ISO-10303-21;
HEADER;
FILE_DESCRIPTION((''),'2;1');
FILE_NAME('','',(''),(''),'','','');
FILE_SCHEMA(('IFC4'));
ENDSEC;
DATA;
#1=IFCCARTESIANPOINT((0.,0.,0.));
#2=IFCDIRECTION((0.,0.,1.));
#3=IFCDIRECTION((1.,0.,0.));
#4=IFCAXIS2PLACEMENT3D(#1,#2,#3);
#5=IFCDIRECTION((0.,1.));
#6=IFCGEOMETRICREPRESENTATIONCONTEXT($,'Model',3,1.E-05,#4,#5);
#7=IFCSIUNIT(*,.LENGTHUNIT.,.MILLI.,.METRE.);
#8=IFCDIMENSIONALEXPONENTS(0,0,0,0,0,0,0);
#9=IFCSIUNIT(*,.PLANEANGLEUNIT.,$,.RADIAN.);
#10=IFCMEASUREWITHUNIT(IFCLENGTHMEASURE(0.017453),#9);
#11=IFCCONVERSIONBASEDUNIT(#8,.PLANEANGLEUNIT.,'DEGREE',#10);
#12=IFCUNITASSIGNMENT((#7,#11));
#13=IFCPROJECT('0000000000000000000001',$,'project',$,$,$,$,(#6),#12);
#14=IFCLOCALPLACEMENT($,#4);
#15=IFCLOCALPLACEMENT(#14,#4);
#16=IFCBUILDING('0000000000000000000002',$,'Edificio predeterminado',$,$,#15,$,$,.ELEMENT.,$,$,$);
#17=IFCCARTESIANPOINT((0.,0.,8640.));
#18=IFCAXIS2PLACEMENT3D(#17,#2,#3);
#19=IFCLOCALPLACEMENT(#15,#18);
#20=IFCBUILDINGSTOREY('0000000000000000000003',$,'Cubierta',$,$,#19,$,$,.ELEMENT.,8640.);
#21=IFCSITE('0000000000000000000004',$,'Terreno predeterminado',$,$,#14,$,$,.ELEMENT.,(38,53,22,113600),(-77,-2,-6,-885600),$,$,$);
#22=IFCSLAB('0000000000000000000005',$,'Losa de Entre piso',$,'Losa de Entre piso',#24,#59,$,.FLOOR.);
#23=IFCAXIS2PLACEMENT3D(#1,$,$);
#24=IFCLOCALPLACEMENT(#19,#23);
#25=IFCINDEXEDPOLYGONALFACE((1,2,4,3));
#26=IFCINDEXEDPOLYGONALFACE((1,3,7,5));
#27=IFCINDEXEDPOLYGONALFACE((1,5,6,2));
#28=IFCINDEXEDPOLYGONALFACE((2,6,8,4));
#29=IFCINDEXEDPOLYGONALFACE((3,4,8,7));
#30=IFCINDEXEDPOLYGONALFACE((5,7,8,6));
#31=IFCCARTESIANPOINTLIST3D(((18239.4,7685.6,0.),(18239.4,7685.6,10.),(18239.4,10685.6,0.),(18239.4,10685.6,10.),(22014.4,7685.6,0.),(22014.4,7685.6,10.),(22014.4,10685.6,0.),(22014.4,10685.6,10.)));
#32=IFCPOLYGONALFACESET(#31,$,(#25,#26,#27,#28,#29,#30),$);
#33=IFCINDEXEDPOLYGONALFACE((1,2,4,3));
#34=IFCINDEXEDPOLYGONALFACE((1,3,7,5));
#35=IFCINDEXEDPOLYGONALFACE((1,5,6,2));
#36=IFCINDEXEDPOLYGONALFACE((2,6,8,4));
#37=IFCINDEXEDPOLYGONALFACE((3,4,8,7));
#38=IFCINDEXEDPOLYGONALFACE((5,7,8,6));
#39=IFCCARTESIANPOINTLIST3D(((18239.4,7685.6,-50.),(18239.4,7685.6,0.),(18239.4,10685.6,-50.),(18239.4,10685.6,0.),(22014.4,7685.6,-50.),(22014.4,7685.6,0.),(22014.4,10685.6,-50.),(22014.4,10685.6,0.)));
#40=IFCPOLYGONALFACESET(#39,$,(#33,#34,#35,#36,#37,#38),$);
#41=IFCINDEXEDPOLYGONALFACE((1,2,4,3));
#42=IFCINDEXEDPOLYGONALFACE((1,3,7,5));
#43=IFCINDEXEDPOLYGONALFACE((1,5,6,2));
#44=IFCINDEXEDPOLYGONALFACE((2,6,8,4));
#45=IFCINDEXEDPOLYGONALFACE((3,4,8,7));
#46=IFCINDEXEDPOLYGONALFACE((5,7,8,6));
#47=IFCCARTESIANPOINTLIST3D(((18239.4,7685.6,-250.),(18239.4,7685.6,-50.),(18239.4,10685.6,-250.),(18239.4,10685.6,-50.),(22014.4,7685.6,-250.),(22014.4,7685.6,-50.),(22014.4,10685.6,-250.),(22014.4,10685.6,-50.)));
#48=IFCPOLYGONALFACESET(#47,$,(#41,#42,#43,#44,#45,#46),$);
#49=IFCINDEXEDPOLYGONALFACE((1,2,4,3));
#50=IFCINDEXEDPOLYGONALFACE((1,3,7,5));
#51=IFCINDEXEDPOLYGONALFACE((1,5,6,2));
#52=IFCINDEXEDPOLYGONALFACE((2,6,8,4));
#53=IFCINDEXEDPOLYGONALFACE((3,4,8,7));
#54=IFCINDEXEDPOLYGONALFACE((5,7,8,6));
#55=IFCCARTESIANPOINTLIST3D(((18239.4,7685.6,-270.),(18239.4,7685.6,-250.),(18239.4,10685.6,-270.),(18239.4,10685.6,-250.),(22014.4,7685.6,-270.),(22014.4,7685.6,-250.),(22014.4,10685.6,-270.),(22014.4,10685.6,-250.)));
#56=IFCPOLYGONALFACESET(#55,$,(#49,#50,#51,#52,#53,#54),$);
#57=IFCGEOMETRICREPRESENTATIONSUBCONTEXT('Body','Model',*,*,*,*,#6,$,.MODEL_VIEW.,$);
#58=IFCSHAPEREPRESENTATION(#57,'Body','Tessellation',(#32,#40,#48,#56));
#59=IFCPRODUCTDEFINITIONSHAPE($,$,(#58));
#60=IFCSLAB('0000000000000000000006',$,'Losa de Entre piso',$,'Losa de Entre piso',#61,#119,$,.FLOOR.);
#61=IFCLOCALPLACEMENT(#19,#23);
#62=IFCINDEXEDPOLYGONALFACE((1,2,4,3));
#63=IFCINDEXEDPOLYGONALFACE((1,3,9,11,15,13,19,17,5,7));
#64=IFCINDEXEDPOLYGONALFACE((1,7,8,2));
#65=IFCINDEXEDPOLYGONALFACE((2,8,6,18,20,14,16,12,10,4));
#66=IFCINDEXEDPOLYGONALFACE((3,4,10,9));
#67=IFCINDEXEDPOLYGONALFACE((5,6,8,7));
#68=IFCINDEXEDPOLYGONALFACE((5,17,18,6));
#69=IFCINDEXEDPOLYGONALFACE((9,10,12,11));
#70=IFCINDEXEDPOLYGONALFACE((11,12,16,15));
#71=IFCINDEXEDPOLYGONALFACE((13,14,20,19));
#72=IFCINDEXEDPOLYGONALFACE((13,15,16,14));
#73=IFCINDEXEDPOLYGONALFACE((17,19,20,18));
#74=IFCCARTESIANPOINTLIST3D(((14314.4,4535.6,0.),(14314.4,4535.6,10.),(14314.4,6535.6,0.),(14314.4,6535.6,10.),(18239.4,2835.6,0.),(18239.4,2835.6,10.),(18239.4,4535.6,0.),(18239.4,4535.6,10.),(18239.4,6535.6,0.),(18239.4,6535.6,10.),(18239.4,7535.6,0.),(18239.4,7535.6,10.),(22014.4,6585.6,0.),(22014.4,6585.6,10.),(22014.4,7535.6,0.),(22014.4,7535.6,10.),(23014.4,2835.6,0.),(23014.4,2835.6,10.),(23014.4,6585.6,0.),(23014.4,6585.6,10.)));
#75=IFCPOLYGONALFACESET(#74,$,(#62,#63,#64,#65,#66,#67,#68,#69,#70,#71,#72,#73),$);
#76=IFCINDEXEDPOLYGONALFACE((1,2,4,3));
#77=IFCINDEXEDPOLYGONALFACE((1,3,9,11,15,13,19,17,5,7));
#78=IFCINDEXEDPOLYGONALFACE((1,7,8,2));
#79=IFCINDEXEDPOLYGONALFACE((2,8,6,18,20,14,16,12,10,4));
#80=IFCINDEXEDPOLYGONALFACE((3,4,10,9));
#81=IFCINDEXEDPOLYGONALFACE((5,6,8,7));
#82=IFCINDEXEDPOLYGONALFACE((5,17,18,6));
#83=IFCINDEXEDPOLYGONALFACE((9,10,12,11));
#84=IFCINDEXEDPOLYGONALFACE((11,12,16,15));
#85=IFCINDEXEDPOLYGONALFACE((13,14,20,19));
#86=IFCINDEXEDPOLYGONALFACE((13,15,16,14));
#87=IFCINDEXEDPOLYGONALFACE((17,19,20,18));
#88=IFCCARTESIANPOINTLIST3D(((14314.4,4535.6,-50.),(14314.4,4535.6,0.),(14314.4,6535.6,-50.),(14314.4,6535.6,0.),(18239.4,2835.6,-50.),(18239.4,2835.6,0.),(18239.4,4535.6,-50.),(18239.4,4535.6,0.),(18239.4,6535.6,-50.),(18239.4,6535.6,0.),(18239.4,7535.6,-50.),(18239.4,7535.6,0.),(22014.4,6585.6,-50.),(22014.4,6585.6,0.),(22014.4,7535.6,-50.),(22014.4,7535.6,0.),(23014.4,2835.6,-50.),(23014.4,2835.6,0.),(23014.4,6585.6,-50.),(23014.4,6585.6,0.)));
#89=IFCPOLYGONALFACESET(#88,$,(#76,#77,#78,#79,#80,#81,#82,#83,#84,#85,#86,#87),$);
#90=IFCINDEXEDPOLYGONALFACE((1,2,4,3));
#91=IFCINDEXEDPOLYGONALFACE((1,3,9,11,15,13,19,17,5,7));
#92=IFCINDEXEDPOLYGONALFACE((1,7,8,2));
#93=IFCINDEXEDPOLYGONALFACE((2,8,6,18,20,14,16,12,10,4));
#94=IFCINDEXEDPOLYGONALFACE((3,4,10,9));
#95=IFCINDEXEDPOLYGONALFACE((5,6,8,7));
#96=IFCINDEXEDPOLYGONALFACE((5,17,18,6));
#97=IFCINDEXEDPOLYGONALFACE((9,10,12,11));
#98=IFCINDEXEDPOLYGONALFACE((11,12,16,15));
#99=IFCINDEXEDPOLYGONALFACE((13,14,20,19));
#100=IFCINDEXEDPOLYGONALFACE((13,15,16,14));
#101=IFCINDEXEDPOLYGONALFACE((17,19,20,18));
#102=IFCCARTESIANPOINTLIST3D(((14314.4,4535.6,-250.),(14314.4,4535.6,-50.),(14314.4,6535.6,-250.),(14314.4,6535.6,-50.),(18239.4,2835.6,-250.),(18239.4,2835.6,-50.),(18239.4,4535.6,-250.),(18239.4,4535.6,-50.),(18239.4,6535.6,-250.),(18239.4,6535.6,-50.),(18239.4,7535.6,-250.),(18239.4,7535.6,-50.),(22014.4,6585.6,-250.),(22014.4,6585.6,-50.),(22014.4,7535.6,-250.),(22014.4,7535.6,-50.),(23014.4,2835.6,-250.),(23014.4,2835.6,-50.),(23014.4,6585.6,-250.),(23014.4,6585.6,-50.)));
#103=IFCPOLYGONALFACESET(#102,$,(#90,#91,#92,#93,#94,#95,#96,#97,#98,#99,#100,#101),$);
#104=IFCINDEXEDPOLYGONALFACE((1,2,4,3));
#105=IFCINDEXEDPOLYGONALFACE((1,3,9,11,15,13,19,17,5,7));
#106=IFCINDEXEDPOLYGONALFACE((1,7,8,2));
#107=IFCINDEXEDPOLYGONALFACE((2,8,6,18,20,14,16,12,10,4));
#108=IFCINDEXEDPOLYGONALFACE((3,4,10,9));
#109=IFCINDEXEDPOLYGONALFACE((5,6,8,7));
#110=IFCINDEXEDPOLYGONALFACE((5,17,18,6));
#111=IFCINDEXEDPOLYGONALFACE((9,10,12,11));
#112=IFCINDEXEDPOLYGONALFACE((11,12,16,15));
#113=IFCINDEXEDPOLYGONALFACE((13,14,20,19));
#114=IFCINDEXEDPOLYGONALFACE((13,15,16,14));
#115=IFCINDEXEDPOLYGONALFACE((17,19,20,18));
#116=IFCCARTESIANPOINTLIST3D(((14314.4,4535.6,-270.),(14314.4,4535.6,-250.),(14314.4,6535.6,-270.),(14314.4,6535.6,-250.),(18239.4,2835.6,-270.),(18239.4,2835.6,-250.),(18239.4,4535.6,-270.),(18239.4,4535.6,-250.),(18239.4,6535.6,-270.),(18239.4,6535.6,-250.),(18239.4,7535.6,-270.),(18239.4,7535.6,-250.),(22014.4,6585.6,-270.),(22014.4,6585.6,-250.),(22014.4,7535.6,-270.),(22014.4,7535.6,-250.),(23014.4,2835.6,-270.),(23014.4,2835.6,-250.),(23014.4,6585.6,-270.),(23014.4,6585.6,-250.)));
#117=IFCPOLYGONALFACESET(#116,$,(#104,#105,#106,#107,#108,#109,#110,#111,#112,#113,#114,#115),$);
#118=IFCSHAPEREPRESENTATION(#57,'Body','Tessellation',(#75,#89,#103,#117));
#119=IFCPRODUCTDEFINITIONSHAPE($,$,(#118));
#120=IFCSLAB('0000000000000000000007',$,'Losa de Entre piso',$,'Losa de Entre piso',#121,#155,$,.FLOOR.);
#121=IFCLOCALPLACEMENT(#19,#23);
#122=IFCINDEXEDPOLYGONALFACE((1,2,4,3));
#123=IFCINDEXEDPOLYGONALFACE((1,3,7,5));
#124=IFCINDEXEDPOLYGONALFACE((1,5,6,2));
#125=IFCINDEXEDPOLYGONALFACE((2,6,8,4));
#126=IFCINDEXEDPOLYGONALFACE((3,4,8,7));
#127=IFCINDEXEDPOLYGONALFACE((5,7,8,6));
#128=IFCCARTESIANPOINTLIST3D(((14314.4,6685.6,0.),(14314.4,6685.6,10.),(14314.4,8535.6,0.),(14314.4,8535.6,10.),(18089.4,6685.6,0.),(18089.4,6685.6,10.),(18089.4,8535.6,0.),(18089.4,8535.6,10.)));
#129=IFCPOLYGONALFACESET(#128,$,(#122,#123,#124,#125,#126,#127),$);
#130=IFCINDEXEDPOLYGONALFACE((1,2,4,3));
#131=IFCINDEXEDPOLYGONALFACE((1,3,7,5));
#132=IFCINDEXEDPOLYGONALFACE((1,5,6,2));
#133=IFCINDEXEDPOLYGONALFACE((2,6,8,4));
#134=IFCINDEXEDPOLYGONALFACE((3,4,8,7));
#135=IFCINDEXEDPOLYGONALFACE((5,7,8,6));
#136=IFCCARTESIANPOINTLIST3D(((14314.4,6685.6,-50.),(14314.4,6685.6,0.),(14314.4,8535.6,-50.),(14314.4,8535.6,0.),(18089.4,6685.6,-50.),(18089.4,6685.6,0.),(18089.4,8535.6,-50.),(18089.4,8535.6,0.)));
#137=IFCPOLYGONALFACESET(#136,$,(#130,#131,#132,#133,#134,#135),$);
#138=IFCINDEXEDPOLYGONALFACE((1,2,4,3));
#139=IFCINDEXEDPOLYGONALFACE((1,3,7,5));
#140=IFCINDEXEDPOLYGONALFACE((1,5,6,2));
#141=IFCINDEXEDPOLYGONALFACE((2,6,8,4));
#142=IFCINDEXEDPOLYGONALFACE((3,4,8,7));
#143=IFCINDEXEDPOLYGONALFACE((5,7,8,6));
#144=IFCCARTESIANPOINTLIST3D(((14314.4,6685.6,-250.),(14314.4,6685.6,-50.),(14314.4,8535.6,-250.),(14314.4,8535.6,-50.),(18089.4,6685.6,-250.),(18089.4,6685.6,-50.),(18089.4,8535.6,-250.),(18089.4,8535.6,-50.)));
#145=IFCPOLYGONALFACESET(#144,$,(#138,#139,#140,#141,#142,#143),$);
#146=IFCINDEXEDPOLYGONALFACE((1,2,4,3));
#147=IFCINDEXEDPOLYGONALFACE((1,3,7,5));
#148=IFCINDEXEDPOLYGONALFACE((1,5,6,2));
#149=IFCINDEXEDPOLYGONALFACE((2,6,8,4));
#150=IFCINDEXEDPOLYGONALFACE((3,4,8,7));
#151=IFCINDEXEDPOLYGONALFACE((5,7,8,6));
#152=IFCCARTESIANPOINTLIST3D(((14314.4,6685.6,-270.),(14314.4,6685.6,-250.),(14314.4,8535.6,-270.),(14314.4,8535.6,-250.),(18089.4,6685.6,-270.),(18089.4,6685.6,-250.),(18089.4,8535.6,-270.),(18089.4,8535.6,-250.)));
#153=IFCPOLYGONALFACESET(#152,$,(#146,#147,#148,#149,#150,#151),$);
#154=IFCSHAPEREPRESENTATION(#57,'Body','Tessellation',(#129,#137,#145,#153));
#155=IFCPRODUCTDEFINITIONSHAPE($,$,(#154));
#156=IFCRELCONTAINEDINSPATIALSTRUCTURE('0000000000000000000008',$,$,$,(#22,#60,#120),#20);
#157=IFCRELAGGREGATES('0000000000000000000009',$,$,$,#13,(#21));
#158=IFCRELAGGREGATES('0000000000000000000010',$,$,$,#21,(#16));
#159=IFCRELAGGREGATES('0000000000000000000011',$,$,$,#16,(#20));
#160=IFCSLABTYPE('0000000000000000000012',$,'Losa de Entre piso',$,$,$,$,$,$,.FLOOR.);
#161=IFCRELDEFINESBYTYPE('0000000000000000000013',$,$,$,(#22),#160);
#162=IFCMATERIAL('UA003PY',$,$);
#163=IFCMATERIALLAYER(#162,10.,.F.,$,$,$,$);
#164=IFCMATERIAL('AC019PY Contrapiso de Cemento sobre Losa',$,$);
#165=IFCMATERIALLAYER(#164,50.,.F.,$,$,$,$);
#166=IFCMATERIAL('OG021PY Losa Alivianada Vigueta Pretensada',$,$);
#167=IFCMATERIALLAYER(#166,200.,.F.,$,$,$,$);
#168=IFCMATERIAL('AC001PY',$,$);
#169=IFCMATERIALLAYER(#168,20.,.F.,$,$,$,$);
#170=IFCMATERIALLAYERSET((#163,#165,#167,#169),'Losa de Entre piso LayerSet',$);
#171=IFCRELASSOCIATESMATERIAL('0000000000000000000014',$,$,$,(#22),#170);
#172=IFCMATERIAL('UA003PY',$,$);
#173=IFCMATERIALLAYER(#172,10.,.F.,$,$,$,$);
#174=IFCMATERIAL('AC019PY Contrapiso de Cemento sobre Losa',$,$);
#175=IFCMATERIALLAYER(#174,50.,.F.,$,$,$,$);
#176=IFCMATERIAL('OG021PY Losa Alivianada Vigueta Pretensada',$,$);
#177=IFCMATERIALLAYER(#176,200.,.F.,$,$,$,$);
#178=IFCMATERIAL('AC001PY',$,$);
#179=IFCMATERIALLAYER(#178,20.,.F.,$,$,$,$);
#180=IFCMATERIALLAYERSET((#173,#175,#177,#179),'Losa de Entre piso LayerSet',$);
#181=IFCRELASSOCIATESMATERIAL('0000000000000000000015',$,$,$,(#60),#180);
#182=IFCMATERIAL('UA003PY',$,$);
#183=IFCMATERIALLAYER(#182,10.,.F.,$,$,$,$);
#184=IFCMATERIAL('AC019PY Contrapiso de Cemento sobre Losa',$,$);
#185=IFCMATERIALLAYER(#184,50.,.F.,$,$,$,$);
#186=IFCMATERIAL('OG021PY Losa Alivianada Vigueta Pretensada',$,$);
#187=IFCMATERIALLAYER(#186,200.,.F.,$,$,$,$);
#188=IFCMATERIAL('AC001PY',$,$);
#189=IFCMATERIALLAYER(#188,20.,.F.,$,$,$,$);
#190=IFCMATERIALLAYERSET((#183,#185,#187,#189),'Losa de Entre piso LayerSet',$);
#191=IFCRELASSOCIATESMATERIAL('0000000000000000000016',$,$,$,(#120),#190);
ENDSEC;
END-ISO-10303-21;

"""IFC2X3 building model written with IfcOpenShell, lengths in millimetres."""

from ifc_helpers import new_model, entity, si_unit, converted_unit, direction, frame, origin_with_axes, place, context, subcontext, project, spatial, polyline, outline, extrude, material, layer, layer_set, layer_usage, type_object, element, save


model = new_model("IFC2X3")

# Units and contexts
model_context = context("Model", 3, precision=1e-05, world=origin_with_axes(), true_north=direction((0.0, 1.0)))
body_context = subcontext(model_context, "Body", "Model", "MODEL_VIEW")
ifc_project = project(units=[si_unit("LENGTHUNIT", "METRE", prefix="MILLI"), converted_unit("PLANEANGLEUNIT", "DEGREE", entity("IfcLengthMeasure", 0.017453), si_unit("PLANEANGLEUNIT", "RADIAN"), dimensions=[0, 0, 0, 0, 0, 0, 0])], contexts=[model_context])

# Site, building, storey
site_placement = place(None, origin_with_axes())
site = spatial("IfcSite", under=ifc_project, at=site_placement, Name="Terreno predeterminado", CompositionType="ELEMENT", RefLatitude=(38, 53, 22, 113600), RefLongitude=(-77, -2, -6, -885600))
building_placement = place(site_placement, origin_with_axes())
building = spatial("IfcBuilding", under=site, at=building_placement, Name="Edificio predeterminado", CompositionType="ELEMENT")
storey_placement = place(building_placement, frame((0.0, 0.0, 8640.0), z_axis=(0.0, 0.0, 1.0), x_axis=(1.0, 0.0, 0.0)))
storey = spatial("IfcBuildingStorey", under=building, at=storey_placement, Name="Cubierta", CompositionType="ELEMENT", Elevation=8640.0)

# Slabs
ifc_material_1 = material(Name="UA003PY")
ifc_layer_1 = layer(ifc_material_1, 10.0, ventilated=False)
ifc_material_2 = material(Name="AC019PY Contrapiso de Cemento sobre Losa")
ifc_layer_2 = layer(ifc_material_2, 50.0, ventilated=False)
ifc_material_3 = material(Name="OG021PY Losa Alivianada Vigueta Pretensada")
ifc_layer_3 = layer(ifc_material_3, 200.0, ventilated=False)
ifc_material_4 = material(Name="AC001PY")
ifc_layer_4 = layer(ifc_material_4, 20.0, ventilated=False)
ifc_layer_set_1 = layer_set([ifc_layer_1, ifc_layer_2, ifc_layer_3, ifc_layer_4], Name="Losa de Entre piso LayerSet")
ifc_layer_usage_1 = layer_usage(ifc_layer_set_1, "AXIS3", "NEGATIVE", 0.0)
slab_type = type_object("IfcSlabType", Name="Losa de Entre piso", PredefinedType="FLOOR")
slab_1_placement = place(storey_placement, frame((0.0, 0.0, -8640.0), z_axis=(0.0, 0.0, 1.0), x_axis=(1.0, 0.0, 0.0)))
element("IfcSlab", 1, at=slab_1_placement, inside=storey, type_object=slab_type, material=ifc_layer_usage_1, Name="Losa de Entre piso", ObjectType="Losa de Entre piso", PredefinedType="FLOOR", context=body_context, shape_type="SweptSolid", body=[
    extrude(outline(polyline([(0.0, 3000.0), (3775.0, 3000.0), (3775.0, 0.0), (0.0, 0.0), (0.0, 3000.0)])), frame((22014.4, 7685.6, 8640.0), z_axis=(0.0, 0.0, -1.0), x_axis=(-1.0, 0.0, 0.0)), (0.0, 0.0, -1.0), 10.0),
    extrude(outline(polyline([(0.0, 3000.0), (3775.0, 3000.0), (3775.0, 0.0), (0.0, 0.0), (0.0, 3000.0)])), frame((22014.4, 7685.6, 8590.0), z_axis=(0.0, 0.0, -1.0), x_axis=(-1.0, 0.0, 0.0)), (0.0, 0.0, -1.0), 50.0),
    extrude(outline(polyline([(0.0, 3000.0), (3775.0, 3000.0), (3775.0, 0.0), (0.0, 0.0), (0.0, 3000.0)])), frame((22014.4, 7685.6, 8390.0), z_axis=(0.0, 0.0, -1.0), x_axis=(-1.0, 0.0, 0.0)), (0.0, 0.0, -1.0), 200.0),
    extrude(outline(polyline([(0.0, 3000.0), (3775.0, 3000.0), (3775.0, 0.0), (0.0, 0.0), (0.0, 3000.0)])), frame((22014.4, 7685.6, 8370.0), z_axis=(0.0, 0.0, -1.0), x_axis=(-1.0, 0.0, 0.0)), (0.0, 0.0, -1.0), 20.0),
])
ifc_material_5 = material(Name="UA003PY")
ifc_layer_5 = layer(ifc_material_5, 10.0, ventilated=False)
ifc_material_6 = material(Name="AC019PY Contrapiso de Cemento sobre Losa")
ifc_layer_6 = layer(ifc_material_6, 50.0, ventilated=False)
ifc_material_7 = material(Name="OG021PY Losa Alivianada Vigueta Pretensada")
ifc_layer_7 = layer(ifc_material_7, 200.0, ventilated=False)
ifc_material_8 = material(Name="AC001PY")
ifc_layer_8 = layer(ifc_material_8, 20.0, ventilated=False)
ifc_layer_set_2 = layer_set([ifc_layer_5, ifc_layer_6, ifc_layer_7, ifc_layer_8], Name="Losa de Entre piso LayerSet")
ifc_layer_usage_2 = layer_usage(ifc_layer_set_2, "AXIS3", "NEGATIVE", 0.0)
slab_2_placement = place(storey_placement, frame((0.0, 0.0, -8640.0), z_axis=(0.0, 0.0, 1.0), x_axis=(1.0, 0.0, 0.0)))
element("IfcSlab", 2, at=slab_2_placement, inside=storey, material=ifc_layer_usage_2, Name="Losa de Entre piso", ObjectType="Losa de Entre piso", PredefinedType="FLOOR", context=body_context, shape_type="SweptSolid", body=[
    extrude(outline(polyline([(0.0, 1000.0), (-3925.0, 1000.0), (-3925.0, 3000.0), (0.0, 3000.0), (0.0, 4700.0), (4775.0, 4700.0), (4775.0, 950.0), (3775.0, 950.0), (3775.0, 0.0), (0.0, 0.0), (0.0, 1000.0)])), frame((18239.4, 7535.6, 8640.0), z_axis=(0.0, 0.0, -1.0), x_axis=(1.0, 0.0, 0.0)), (0.0, 0.0, -1.0), 10.0),
    extrude(outline(polyline([(0.0, 1000.0), (-3925.0, 1000.0), (-3925.0, 3000.0), (0.0, 3000.0), (0.0, 4700.0), (4775.0, 4700.0), (4775.0, 950.0), (3775.0, 950.0), (3775.0, 0.0), (0.0, 0.0), (0.0, 1000.0)])), frame((18239.4, 7535.6, 8590.0), z_axis=(0.0, 0.0, -1.0), x_axis=(1.0, 0.0, 0.0)), (0.0, 0.0, -1.0), 50.0),
    extrude(outline(polyline([(0.0, 1000.0), (-3925.0, 1000.0), (-3925.0, 3000.0), (0.0, 3000.0), (0.0, 4700.0), (4775.0, 4700.0), (4775.0, 950.0), (3775.0, 950.0), (3775.0, 0.0), (0.0, 0.0), (0.0, 1000.0)])), frame((18239.4, 7535.6, 8390.0), z_axis=(0.0, 0.0, -1.0), x_axis=(1.0, 0.0, 0.0)), (0.0, 0.0, -1.0), 200.0),
    extrude(outline(polyline([(0.0, 1000.0), (-3925.0, 1000.0), (-3925.0, 3000.0), (0.0, 3000.0), (0.0, 4700.0), (4775.0, 4700.0), (4775.0, 950.0), (3775.0, 950.0), (3775.0, 0.0), (0.0, 0.0), (0.0, 1000.0)])), frame((18239.4, 7535.6, 8370.0), z_axis=(0.0, 0.0, -1.0), x_axis=(1.0, 0.0, 0.0)), (0.0, 0.0, -1.0), 20.0),
])
ifc_material_9 = material(Name="UA003PY")
ifc_layer_9 = layer(ifc_material_9, 10.0, ventilated=False)
ifc_material_10 = material(Name="AC019PY Contrapiso de Cemento sobre Losa")
ifc_layer_10 = layer(ifc_material_10, 50.0, ventilated=False)
ifc_material_11 = material(Name="OG021PY Losa Alivianada Vigueta Pretensada")
ifc_layer_11 = layer(ifc_material_11, 200.0, ventilated=False)
ifc_material_12 = material(Name="AC001PY")
ifc_layer_12 = layer(ifc_material_12, 20.0, ventilated=False)
ifc_layer_set_3 = layer_set([ifc_layer_9, ifc_layer_10, ifc_layer_11, ifc_layer_12], Name="Losa de Entre piso LayerSet")
ifc_layer_usage_3 = layer_usage(ifc_layer_set_3, "AXIS3", "NEGATIVE", 0.0)
slab_3_placement = place(storey_placement, frame((0.0, 0.0, -8640.0), z_axis=(0.0, 0.0, 1.0), x_axis=(1.0, 0.0, 0.0)))
element("IfcSlab", 3, at=slab_3_placement, inside=storey, material=ifc_layer_usage_3, Name="Losa de Entre piso", ObjectType="Losa de Entre piso", PredefinedType="FLOOR", context=body_context, shape_type="SweptSolid", body=[
    extrude(outline(polyline([(0.0, 1850.0), (3775.0, 1850.0), (3775.0, 0.0), (0.0, 0.0), (0.0, 1850.0)])), frame((18089.4, 6685.6, 8640.0), z_axis=(0.0, 0.0, -1.0), x_axis=(-1.0, 0.0, 0.0)), (0.0, 0.0, -1.0), 10.0),
    extrude(outline(polyline([(0.0, 1850.0), (3775.0, 1850.0), (3775.0, 0.0), (0.0, 0.0), (0.0, 1850.0)])), frame((18089.4, 6685.6, 8590.0), z_axis=(0.0, 0.0, -1.0), x_axis=(-1.0, 0.0, 0.0)), (0.0, 0.0, -1.0), 50.0),
    extrude(outline(polyline([(0.0, 1850.0), (3775.0, 1850.0), (3775.0, 0.0), (0.0, 0.0), (0.0, 1850.0)])), frame((18089.4, 6685.6, 8390.0), z_axis=(0.0, 0.0, -1.0), x_axis=(-1.0, 0.0, 0.0)), (0.0, 0.0, -1.0), 200.0),
    extrude(outline(polyline([(0.0, 1850.0), (3775.0, 1850.0), (3775.0, 0.0), (0.0, 0.0), (0.0, 1850.0)])), frame((18089.4, 6685.6, 8370.0), z_axis=(0.0, 0.0, -1.0), x_axis=(-1.0, 0.0, 0.0)), (0.0, 0.0, -1.0), 20.0),
])

save(model, "model.ifc")
